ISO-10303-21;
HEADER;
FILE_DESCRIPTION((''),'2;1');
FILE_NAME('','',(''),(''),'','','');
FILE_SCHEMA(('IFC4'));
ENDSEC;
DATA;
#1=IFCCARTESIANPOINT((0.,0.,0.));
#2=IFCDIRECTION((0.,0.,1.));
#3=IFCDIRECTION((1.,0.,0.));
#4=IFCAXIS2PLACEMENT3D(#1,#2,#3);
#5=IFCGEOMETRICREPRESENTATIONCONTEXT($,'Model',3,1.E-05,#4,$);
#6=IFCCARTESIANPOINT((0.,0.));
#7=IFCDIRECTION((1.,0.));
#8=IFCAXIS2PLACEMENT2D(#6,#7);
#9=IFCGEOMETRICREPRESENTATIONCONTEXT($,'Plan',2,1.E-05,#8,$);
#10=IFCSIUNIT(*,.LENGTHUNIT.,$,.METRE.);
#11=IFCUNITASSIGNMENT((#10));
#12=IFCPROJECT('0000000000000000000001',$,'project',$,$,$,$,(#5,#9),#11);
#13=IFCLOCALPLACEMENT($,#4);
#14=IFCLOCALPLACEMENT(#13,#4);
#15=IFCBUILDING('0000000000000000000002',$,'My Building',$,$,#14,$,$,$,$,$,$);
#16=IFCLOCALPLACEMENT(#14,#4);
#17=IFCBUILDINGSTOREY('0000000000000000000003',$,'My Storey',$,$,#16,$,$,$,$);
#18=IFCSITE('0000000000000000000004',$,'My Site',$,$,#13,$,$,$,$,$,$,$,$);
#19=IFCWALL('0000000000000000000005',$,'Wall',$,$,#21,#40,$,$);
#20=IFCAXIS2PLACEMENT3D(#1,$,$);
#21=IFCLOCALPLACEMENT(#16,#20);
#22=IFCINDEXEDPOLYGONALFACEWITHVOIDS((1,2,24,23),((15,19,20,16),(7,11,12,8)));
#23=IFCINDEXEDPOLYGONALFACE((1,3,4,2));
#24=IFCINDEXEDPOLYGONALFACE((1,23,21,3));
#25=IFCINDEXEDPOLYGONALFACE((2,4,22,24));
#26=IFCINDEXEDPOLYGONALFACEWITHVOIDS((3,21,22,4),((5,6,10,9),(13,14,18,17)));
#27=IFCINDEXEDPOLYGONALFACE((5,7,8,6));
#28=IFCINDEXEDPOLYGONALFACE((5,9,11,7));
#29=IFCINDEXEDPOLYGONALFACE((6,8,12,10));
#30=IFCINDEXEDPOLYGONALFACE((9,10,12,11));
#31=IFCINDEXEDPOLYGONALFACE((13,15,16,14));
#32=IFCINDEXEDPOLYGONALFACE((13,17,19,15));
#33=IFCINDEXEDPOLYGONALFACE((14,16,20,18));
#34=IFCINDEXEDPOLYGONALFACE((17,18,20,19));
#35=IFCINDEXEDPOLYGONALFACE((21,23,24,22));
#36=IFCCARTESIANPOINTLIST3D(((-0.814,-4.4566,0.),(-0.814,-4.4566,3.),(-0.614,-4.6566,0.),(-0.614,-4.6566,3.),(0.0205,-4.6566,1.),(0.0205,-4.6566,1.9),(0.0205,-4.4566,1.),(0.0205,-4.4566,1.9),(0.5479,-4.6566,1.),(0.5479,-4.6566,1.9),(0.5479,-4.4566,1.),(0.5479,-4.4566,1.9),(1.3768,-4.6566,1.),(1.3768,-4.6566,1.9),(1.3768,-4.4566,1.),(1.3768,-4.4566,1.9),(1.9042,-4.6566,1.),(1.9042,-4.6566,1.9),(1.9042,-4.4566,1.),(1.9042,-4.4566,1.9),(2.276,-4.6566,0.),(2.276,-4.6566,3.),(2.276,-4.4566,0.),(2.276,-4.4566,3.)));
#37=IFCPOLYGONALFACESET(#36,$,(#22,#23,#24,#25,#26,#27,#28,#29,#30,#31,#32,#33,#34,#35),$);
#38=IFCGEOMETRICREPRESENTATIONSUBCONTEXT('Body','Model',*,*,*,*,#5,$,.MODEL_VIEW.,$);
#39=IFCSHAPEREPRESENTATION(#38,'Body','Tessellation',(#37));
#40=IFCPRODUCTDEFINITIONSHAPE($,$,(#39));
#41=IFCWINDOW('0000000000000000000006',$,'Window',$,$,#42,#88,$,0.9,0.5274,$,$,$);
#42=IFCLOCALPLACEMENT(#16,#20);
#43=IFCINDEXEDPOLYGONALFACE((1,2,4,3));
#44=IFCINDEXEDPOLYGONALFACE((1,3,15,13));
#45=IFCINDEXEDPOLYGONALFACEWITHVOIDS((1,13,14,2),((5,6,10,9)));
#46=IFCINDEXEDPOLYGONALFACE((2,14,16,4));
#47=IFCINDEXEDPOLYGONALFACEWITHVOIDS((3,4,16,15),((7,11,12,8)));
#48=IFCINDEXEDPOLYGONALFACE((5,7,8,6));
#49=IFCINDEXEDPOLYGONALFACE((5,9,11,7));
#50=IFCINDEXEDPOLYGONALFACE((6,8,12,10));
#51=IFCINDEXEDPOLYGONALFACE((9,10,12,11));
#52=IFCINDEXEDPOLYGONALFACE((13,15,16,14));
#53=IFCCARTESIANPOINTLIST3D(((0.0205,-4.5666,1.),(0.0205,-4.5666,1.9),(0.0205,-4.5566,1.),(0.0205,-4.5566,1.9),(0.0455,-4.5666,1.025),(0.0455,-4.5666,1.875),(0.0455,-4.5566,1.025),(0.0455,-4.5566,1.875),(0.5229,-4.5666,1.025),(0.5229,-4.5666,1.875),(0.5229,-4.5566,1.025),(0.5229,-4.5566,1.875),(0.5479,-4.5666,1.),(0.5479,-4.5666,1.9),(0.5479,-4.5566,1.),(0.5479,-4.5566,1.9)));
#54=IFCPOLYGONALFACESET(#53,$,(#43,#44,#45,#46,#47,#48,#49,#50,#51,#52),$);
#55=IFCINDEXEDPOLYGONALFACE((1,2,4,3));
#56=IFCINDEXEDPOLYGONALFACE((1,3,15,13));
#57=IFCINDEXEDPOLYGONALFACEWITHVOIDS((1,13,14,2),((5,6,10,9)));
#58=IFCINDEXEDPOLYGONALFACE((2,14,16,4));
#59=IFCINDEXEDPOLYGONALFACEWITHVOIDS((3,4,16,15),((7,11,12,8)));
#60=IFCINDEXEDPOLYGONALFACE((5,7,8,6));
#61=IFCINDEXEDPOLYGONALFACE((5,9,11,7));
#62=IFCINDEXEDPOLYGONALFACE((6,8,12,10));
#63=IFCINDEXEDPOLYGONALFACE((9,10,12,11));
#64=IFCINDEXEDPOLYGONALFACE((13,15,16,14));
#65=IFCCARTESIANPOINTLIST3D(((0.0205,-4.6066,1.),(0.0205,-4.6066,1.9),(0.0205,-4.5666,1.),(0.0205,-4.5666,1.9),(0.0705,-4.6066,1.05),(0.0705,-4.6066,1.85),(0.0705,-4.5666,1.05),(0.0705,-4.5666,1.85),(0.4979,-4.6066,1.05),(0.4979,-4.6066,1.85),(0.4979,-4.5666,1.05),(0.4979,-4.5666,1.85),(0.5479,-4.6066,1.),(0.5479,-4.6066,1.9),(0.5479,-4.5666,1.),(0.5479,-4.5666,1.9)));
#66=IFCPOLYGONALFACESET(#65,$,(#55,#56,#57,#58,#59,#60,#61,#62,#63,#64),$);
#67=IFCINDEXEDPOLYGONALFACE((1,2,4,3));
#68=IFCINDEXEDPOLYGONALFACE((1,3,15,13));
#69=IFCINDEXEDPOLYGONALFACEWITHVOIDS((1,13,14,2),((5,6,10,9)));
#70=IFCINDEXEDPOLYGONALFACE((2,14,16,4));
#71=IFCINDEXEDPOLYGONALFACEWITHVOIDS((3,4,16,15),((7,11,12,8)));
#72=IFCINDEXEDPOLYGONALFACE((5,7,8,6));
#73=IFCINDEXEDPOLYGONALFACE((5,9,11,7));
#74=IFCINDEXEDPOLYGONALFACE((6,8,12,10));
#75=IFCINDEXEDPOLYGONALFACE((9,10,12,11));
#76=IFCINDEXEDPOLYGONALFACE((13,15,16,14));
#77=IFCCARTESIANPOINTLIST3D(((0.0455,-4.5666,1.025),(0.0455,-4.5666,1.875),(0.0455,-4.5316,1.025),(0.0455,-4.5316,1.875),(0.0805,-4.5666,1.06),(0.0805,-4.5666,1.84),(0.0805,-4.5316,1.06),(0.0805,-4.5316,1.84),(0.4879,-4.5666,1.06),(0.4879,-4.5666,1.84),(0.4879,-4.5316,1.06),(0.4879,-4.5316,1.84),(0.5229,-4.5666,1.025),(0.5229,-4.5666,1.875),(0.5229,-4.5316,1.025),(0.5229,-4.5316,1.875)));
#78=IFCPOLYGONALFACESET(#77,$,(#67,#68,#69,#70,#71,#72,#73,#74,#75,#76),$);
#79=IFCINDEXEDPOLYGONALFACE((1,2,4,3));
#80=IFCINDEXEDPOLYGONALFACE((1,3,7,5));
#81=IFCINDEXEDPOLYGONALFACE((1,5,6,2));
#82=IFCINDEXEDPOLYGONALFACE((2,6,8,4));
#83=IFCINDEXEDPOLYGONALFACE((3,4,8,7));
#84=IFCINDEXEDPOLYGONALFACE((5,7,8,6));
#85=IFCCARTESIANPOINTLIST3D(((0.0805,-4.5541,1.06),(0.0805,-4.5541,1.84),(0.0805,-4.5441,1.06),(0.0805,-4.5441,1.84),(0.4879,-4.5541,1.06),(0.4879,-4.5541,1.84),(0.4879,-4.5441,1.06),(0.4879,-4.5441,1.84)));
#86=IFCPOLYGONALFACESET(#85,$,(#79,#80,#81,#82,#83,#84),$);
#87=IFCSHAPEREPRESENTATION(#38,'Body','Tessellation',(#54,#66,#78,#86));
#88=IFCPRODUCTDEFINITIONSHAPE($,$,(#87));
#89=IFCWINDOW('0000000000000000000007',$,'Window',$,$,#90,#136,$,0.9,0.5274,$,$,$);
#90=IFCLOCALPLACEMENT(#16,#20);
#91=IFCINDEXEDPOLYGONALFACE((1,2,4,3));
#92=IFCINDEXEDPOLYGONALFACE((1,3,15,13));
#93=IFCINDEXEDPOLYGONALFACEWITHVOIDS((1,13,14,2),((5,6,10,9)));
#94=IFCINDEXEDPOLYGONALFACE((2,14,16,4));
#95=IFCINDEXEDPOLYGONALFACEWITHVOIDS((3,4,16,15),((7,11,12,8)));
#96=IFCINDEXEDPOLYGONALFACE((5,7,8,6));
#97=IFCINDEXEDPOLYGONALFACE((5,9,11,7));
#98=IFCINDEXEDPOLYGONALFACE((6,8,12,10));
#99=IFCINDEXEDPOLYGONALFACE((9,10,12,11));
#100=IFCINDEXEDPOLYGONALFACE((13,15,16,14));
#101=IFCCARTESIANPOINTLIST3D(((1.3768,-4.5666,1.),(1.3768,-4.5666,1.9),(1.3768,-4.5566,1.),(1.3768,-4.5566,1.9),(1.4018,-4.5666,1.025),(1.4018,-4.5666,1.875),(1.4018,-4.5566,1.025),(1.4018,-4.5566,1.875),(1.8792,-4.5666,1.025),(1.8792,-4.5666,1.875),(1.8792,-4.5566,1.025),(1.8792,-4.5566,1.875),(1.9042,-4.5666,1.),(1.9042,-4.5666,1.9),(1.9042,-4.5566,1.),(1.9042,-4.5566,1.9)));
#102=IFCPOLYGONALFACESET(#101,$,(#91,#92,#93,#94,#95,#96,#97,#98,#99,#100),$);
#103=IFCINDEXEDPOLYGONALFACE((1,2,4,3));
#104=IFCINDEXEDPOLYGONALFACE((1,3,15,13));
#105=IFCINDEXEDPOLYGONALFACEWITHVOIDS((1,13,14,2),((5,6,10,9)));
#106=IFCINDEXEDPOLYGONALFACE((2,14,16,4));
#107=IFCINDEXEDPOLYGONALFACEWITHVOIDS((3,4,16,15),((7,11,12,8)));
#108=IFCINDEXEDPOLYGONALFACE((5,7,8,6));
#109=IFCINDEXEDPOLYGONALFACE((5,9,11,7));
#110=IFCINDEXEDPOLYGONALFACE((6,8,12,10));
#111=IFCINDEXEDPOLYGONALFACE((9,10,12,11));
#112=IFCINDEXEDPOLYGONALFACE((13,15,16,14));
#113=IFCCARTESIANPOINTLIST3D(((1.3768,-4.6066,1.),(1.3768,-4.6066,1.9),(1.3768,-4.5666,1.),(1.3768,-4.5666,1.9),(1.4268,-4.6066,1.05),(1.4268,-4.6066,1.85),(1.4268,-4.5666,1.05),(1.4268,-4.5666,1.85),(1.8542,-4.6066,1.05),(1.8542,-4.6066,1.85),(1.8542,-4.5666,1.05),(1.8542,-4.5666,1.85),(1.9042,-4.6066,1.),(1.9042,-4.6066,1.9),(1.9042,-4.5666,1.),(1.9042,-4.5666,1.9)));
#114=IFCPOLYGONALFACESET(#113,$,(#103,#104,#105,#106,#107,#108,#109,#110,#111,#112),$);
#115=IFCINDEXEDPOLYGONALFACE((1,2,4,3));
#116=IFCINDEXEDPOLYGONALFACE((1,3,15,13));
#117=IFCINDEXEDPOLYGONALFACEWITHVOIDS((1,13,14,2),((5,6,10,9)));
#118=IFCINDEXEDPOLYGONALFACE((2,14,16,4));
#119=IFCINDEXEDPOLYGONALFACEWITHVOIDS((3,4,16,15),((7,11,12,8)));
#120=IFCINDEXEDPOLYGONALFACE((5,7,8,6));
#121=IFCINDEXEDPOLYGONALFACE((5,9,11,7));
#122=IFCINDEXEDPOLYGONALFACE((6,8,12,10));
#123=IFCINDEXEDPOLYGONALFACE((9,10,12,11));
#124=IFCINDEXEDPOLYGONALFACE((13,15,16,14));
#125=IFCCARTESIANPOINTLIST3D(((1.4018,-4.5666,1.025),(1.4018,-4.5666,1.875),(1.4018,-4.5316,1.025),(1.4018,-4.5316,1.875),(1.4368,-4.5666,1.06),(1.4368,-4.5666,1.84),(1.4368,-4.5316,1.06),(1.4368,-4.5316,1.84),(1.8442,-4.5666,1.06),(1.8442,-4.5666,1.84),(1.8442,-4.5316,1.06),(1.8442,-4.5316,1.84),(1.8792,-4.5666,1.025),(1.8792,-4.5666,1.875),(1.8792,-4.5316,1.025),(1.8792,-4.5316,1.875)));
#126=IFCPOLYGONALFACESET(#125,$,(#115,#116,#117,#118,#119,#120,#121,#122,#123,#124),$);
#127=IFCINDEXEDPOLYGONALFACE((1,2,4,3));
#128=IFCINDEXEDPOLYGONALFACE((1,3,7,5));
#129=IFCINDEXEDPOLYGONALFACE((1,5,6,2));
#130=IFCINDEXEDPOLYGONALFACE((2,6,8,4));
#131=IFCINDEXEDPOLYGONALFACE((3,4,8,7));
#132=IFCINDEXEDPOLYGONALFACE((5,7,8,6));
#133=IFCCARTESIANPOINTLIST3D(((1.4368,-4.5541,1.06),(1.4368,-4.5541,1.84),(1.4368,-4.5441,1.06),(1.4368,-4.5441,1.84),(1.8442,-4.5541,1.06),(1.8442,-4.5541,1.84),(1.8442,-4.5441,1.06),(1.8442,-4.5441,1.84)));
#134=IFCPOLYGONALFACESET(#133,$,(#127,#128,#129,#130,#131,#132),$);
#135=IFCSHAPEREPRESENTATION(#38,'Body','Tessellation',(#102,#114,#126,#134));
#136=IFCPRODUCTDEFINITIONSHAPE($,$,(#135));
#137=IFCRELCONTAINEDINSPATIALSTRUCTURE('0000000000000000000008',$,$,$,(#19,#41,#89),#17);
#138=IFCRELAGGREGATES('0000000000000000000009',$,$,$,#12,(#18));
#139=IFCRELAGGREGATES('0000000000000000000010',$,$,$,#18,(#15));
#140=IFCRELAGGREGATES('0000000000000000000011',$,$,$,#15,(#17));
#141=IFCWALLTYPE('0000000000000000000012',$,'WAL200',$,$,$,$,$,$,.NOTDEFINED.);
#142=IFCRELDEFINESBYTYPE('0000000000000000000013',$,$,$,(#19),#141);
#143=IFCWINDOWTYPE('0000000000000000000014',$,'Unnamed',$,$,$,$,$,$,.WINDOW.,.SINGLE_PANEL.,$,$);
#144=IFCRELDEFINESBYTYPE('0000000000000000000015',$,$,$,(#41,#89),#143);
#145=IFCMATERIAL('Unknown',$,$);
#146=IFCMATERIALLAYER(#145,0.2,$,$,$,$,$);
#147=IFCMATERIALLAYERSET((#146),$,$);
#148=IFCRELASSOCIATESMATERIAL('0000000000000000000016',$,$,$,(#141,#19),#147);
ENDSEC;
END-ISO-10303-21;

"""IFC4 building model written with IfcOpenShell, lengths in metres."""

from ifc_helpers import new_model, entity, si_unit, frame, origin_with_axes, origin_2d_with_axis, place, context, subcontext, project, spatial, line, indexed_curve, outline, extrude, shape, source, transform, mapped, material, layer, layer_set, layer_usage, type_object, type_shapes, element, fill, save


model = new_model("IFC4")

# Units and contexts
model_context = context("Model", 3, precision=1e-05, world=origin_with_axes())
plan_context = context("Plan", 2, precision=1e-05, world=origin_2d_with_axis())
body_context_1 = subcontext(model_context, "Body", "Model", "MODEL_VIEW")
body_context_2 = subcontext(plan_context, "Body", "Plan", "PLAN_VIEW")
ifc_project = project(units=[si_unit("LENGTHUNIT", "METRE")], contexts=[model_context, plan_context])

# Site, building, storey
site_placement = place(None, origin_with_axes())
site = spatial("IfcSite", under=ifc_project, at=site_placement, Name="My Site")
building_placement = place(site_placement, origin_with_axes())
building = spatial("IfcBuilding", under=site, at=building_placement, Name="My Building")
storey_placement = place(building_placement, origin_with_axes())
storey = spatial("IfcBuildingStorey", under=building, at=storey_placement, Name="My Storey")

# Shared definitions
ifc_material = material(Name="Unknown")

# Wall, openings, windows
ifc_layer_1 = layer(ifc_material, 0.2)
ifc_layer_set_1 = layer_set([ifc_layer_1])
ifc_layer_usage_1 = layer_usage(ifc_layer_set_1, "AXIS2", "POSITIVE", 0.0)
wall_type_1 = type_object("IfcWallType", Name="WAL200", PredefinedType="NOTDEFINED", material=ifc_layer_set_1)
wall_1_placement = place(storey_placement, frame((2.276, -4.4566, 0.0), z_axis=(0.0, 0.0, 1.0), x_axis=(-1.0, 0.0, 0.0)))
wall_1 = element("IfcWall", 1, at=wall_1_placement, inside=storey, type_object=wall_type_1, material=ifc_layer_usage_1, Name="Wall", context=body_context_1, shape_type="SweptSolid", body=[
    extrude(outline(indexed_curve([(0.0, 0.0), (0.0, 0.2), (2.89, 0.2), (3.09, 0.0)], segments=[line(1, 2, 3, 4, 1)])), origin_with_axes(), (0.0, 0.0, 1.0), 3.0),
])
shared_shape_1 = source(origin_with_axes(), body_context_1, "Body", "SweptSolid", [
    extrude(outline(indexed_curve([(0.0, 0.0), (0.5274, 0.0), (0.5274, 0.9), (0.0, 0.9)], segments=[line(1, 2, 3, 4, 1)])), frame((0.0, -0.6, 0.0), z_axis=(0.0, -1.0, 0.0), x_axis=(1.0, 0.0, 0.0)), (0.0, 0.0, -1.0), 1.2),
])
opening_1_placement = place(wall_1_placement, frame((2.2554, 0.2, 1.0), z_axis=(0.0, 0.0, 1.0), x_axis=(-1.0, 0.0, 0.0)))
opening_1 = element("IfcOpeningElement", 2, at=opening_1_placement, cuts=wall_1, PredefinedType="OPENING", context=body_context_1, shape_type="MappedRepresentation", body=[
    mapped(shared_shape_1, transform((0.0, 0.0, 0.0), x_axis=(1.0, 0.0, 0.0), y_axis=(0.0, 1.0, 0.0), z_axis=(0.0, 0.0, 1.0), scale=1.0)),
])
opening_2_placement = place(wall_1_placement, frame((0.8992, 0.2, 1.0), z_axis=(0.0, 0.0, 1.0), x_axis=(-1.0, 0.0, 0.0)))
opening_2 = element("IfcOpeningElement", 3, at=opening_2_placement, cuts=wall_1, PredefinedType="OPENING", context=body_context_1, shape_type="MappedRepresentation", body=[
    mapped(shared_shape_1, transform((0.0, 0.0, 0.0), x_axis=(1.0, 0.0, 0.0), y_axis=(0.0, 1.0, 0.0), z_axis=(0.0, 0.0, 1.0), scale=1.0)),
])
window_type_1 = type_object("IfcWindowType", Name="Unnamed", PartitioningType="SINGLE_PANEL", PredefinedType="WINDOW")
shared_shape_2 = source(origin_with_axes(), body_context_1, "Body", "SweptSolid", [
    extrude(outline(indexed_curve([(0.0, 0.0), (0.5274, 0.0), (0.5274, 0.9), (0.0, 0.9)], segments=[line(1, 2, 3, 4, 1)]), holes=[indexed_curve([(0.025, 0.025), (0.5024, 0.025), (0.5024, 0.875), (0.025, 0.875)], segments=[line(1, 2, 3, 4, 1)])]), frame((0.0, 0.09, 0.0), z_axis=(0.0, -1.0, 0.0), x_axis=(1.0, 0.0, 0.0)), (0.0, 0.0, -1.0), 0.01),
    extrude(outline(indexed_curve([(0.0, 0.0), (0.5274, 0.0), (0.5274, 0.9), (0.0, 0.9)], segments=[line(1, 2, 3, 4, 1)]), holes=[indexed_curve([(0.05, 0.05), (0.4774, 0.05), (0.4774, 0.85), (0.05, 0.85)], segments=[line(1, 2, 3, 4, 1)])]), frame((0.0, 0.05, 0.0), z_axis=(0.0, -1.0, 0.0), x_axis=(1.0, 0.0, 0.0)), (0.0, 0.0, -1.0), 0.04),
    extrude(outline(indexed_curve([(0.0, 0.0), (0.4774, 0.0), (0.4774, 0.85), (0.0, 0.85)], segments=[line(1, 2, 3, 4, 1)]), holes=[indexed_curve([(0.035, 0.035), (0.4424, 0.035), (0.4424, 0.815), (0.035, 0.815)], segments=[line(1, 2, 3, 4, 1)])]), frame((0.025, 0.09, 0.025), z_axis=(0.0, -1.0, 0.0), x_axis=(1.0, 0.0, 0.0)), (0.0, 0.0, -1.0), 0.035),
    extrude(outline(indexed_curve([(0.035, 0.035), (0.4424, 0.035), (0.4424, 0.815), (0.035, 0.815)], segments=[line(1, 2, 3, 4, 1)])), frame((0.025, 0.1025, 0.025), z_axis=(0.0, -1.0, 0.0), x_axis=(1.0, 0.0, 0.0)), (0.0, 0.0, -1.0), 0.01),
])
shared_shape_3 = source(origin_with_axes(), body_context_2, "Body", "Curve2D", [
    entity("IfcIndexedPolyCurve", entity("IfcCartesianPointList2D", [[0.05, 0.05], [0.4774, 0.05]])),
    entity("IfcIndexedPolyCurve", entity("IfcCartesianPointList2D", [[0.0, 0.1], [0.025, 0.1], [0.025, 0.09], [0.05, 0.09], [0.05, 0.05], [0.0, 0.05]]), [entity("IfcLineIndex", [1, 2, 3, 4, 5, 6, 1])]),
    entity("IfcIndexedPolyCurve", entity("IfcCartesianPointList2D", [[0.5274, 0.1], [0.5024, 0.1], [0.5024, 0.09], [0.4774, 0.09], [0.4774, 0.05], [0.5274, 0.05]]), [entity("IfcLineIndex", [1, 2, 3, 4, 5, 6, 1])]),
    entity("IfcIndexedPolyCurve", entity("IfcCartesianPointList2D", [[0.025, 0.09], [0.06, 0.09], [0.06, 0.125], [0.025, 0.125]]), [entity("IfcLineIndex", [1, 2, 3, 4, 1])]),
    entity("IfcIndexedPolyCurve", entity("IfcCartesianPointList2D", [[0.5024, 0.09], [0.4674, 0.09], [0.4674, 0.125], [0.5024, 0.125]]), [entity("IfcLineIndex", [1, 2, 3, 4, 1])]),
    entity("IfcIndexedPolyCurve", entity("IfcCartesianPointList2D", [[0.06, 0.09], [0.4674, 0.09]])),
    entity("IfcIndexedPolyCurve", entity("IfcCartesianPointList2D", [[0.06, 0.125], [0.4674, 0.125]])),
    entity("IfcIndexedPolyCurve", entity("IfcCartesianPointList2D", [[0.06, 0.1075], [0.4674, 0.1075]])),
])
type_shapes(window_type_1, [shared_shape_2, shared_shape_3])
window_1_placement = place(opening_1_placement, frame((0.0, 0.0, 0.0), z_axis=(0.0, 0.0, 1.0), x_axis=(1.0, 0.0, 0.0)))
window_1 = element("IfcWindow", 4, at=window_1_placement, inside=storey, type_object=window_type_1, Name="Window", OverallHeight=0.9, OverallWidth=0.5274, shapes=[
    shape(body_context_1, "Body", "MappedRepresentation", [mapped(shared_shape_2, transform((0.0, 0.0, 0.0), x_axis=(1.0, 0.0, 0.0), y_axis=(0.0, 1.0, 0.0), z_axis=(0.0, 0.0, 1.0), scale=1.0))]),
    shape(body_context_2, "Body", "MappedRepresentation", [mapped(shared_shape_3, transform((0.0, 0.0, 0.0), x_axis=(1.0, 0.0, 0.0), y_axis=(0.0, 1.0, 0.0), z_axis=(0.0, 0.0, 1.0), scale=1.0))]),
])
fill(opening_1, window_1)
window_2_placement = place(opening_2_placement, frame((0.0, 0.0, 0.0), z_axis=(0.0, 0.0, 1.0), x_axis=(1.0, 0.0, 0.0)))
window_2 = element("IfcWindow", 5, at=window_2_placement, inside=storey, type_object=window_type_1, Name="Window", OverallHeight=0.9, OverallWidth=0.5274, shapes=[
    shape(body_context_1, "Body", "MappedRepresentation", [mapped(shared_shape_2, transform((0.0, 0.0, 0.0), x_axis=(1.0, 0.0, 0.0), y_axis=(0.0, 1.0, 0.0), z_axis=(0.0, 0.0, 1.0), scale=1.0))]),
    shape(body_context_2, "Body", "MappedRepresentation", [mapped(shared_shape_3, transform((0.0, 0.0, 0.0), x_axis=(1.0, 0.0, 0.0), y_axis=(0.0, 1.0, 0.0), z_axis=(0.0, 0.0, 1.0), scale=1.0))]),
])
fill(opening_2, window_2)

save(model, "model.ifc")
